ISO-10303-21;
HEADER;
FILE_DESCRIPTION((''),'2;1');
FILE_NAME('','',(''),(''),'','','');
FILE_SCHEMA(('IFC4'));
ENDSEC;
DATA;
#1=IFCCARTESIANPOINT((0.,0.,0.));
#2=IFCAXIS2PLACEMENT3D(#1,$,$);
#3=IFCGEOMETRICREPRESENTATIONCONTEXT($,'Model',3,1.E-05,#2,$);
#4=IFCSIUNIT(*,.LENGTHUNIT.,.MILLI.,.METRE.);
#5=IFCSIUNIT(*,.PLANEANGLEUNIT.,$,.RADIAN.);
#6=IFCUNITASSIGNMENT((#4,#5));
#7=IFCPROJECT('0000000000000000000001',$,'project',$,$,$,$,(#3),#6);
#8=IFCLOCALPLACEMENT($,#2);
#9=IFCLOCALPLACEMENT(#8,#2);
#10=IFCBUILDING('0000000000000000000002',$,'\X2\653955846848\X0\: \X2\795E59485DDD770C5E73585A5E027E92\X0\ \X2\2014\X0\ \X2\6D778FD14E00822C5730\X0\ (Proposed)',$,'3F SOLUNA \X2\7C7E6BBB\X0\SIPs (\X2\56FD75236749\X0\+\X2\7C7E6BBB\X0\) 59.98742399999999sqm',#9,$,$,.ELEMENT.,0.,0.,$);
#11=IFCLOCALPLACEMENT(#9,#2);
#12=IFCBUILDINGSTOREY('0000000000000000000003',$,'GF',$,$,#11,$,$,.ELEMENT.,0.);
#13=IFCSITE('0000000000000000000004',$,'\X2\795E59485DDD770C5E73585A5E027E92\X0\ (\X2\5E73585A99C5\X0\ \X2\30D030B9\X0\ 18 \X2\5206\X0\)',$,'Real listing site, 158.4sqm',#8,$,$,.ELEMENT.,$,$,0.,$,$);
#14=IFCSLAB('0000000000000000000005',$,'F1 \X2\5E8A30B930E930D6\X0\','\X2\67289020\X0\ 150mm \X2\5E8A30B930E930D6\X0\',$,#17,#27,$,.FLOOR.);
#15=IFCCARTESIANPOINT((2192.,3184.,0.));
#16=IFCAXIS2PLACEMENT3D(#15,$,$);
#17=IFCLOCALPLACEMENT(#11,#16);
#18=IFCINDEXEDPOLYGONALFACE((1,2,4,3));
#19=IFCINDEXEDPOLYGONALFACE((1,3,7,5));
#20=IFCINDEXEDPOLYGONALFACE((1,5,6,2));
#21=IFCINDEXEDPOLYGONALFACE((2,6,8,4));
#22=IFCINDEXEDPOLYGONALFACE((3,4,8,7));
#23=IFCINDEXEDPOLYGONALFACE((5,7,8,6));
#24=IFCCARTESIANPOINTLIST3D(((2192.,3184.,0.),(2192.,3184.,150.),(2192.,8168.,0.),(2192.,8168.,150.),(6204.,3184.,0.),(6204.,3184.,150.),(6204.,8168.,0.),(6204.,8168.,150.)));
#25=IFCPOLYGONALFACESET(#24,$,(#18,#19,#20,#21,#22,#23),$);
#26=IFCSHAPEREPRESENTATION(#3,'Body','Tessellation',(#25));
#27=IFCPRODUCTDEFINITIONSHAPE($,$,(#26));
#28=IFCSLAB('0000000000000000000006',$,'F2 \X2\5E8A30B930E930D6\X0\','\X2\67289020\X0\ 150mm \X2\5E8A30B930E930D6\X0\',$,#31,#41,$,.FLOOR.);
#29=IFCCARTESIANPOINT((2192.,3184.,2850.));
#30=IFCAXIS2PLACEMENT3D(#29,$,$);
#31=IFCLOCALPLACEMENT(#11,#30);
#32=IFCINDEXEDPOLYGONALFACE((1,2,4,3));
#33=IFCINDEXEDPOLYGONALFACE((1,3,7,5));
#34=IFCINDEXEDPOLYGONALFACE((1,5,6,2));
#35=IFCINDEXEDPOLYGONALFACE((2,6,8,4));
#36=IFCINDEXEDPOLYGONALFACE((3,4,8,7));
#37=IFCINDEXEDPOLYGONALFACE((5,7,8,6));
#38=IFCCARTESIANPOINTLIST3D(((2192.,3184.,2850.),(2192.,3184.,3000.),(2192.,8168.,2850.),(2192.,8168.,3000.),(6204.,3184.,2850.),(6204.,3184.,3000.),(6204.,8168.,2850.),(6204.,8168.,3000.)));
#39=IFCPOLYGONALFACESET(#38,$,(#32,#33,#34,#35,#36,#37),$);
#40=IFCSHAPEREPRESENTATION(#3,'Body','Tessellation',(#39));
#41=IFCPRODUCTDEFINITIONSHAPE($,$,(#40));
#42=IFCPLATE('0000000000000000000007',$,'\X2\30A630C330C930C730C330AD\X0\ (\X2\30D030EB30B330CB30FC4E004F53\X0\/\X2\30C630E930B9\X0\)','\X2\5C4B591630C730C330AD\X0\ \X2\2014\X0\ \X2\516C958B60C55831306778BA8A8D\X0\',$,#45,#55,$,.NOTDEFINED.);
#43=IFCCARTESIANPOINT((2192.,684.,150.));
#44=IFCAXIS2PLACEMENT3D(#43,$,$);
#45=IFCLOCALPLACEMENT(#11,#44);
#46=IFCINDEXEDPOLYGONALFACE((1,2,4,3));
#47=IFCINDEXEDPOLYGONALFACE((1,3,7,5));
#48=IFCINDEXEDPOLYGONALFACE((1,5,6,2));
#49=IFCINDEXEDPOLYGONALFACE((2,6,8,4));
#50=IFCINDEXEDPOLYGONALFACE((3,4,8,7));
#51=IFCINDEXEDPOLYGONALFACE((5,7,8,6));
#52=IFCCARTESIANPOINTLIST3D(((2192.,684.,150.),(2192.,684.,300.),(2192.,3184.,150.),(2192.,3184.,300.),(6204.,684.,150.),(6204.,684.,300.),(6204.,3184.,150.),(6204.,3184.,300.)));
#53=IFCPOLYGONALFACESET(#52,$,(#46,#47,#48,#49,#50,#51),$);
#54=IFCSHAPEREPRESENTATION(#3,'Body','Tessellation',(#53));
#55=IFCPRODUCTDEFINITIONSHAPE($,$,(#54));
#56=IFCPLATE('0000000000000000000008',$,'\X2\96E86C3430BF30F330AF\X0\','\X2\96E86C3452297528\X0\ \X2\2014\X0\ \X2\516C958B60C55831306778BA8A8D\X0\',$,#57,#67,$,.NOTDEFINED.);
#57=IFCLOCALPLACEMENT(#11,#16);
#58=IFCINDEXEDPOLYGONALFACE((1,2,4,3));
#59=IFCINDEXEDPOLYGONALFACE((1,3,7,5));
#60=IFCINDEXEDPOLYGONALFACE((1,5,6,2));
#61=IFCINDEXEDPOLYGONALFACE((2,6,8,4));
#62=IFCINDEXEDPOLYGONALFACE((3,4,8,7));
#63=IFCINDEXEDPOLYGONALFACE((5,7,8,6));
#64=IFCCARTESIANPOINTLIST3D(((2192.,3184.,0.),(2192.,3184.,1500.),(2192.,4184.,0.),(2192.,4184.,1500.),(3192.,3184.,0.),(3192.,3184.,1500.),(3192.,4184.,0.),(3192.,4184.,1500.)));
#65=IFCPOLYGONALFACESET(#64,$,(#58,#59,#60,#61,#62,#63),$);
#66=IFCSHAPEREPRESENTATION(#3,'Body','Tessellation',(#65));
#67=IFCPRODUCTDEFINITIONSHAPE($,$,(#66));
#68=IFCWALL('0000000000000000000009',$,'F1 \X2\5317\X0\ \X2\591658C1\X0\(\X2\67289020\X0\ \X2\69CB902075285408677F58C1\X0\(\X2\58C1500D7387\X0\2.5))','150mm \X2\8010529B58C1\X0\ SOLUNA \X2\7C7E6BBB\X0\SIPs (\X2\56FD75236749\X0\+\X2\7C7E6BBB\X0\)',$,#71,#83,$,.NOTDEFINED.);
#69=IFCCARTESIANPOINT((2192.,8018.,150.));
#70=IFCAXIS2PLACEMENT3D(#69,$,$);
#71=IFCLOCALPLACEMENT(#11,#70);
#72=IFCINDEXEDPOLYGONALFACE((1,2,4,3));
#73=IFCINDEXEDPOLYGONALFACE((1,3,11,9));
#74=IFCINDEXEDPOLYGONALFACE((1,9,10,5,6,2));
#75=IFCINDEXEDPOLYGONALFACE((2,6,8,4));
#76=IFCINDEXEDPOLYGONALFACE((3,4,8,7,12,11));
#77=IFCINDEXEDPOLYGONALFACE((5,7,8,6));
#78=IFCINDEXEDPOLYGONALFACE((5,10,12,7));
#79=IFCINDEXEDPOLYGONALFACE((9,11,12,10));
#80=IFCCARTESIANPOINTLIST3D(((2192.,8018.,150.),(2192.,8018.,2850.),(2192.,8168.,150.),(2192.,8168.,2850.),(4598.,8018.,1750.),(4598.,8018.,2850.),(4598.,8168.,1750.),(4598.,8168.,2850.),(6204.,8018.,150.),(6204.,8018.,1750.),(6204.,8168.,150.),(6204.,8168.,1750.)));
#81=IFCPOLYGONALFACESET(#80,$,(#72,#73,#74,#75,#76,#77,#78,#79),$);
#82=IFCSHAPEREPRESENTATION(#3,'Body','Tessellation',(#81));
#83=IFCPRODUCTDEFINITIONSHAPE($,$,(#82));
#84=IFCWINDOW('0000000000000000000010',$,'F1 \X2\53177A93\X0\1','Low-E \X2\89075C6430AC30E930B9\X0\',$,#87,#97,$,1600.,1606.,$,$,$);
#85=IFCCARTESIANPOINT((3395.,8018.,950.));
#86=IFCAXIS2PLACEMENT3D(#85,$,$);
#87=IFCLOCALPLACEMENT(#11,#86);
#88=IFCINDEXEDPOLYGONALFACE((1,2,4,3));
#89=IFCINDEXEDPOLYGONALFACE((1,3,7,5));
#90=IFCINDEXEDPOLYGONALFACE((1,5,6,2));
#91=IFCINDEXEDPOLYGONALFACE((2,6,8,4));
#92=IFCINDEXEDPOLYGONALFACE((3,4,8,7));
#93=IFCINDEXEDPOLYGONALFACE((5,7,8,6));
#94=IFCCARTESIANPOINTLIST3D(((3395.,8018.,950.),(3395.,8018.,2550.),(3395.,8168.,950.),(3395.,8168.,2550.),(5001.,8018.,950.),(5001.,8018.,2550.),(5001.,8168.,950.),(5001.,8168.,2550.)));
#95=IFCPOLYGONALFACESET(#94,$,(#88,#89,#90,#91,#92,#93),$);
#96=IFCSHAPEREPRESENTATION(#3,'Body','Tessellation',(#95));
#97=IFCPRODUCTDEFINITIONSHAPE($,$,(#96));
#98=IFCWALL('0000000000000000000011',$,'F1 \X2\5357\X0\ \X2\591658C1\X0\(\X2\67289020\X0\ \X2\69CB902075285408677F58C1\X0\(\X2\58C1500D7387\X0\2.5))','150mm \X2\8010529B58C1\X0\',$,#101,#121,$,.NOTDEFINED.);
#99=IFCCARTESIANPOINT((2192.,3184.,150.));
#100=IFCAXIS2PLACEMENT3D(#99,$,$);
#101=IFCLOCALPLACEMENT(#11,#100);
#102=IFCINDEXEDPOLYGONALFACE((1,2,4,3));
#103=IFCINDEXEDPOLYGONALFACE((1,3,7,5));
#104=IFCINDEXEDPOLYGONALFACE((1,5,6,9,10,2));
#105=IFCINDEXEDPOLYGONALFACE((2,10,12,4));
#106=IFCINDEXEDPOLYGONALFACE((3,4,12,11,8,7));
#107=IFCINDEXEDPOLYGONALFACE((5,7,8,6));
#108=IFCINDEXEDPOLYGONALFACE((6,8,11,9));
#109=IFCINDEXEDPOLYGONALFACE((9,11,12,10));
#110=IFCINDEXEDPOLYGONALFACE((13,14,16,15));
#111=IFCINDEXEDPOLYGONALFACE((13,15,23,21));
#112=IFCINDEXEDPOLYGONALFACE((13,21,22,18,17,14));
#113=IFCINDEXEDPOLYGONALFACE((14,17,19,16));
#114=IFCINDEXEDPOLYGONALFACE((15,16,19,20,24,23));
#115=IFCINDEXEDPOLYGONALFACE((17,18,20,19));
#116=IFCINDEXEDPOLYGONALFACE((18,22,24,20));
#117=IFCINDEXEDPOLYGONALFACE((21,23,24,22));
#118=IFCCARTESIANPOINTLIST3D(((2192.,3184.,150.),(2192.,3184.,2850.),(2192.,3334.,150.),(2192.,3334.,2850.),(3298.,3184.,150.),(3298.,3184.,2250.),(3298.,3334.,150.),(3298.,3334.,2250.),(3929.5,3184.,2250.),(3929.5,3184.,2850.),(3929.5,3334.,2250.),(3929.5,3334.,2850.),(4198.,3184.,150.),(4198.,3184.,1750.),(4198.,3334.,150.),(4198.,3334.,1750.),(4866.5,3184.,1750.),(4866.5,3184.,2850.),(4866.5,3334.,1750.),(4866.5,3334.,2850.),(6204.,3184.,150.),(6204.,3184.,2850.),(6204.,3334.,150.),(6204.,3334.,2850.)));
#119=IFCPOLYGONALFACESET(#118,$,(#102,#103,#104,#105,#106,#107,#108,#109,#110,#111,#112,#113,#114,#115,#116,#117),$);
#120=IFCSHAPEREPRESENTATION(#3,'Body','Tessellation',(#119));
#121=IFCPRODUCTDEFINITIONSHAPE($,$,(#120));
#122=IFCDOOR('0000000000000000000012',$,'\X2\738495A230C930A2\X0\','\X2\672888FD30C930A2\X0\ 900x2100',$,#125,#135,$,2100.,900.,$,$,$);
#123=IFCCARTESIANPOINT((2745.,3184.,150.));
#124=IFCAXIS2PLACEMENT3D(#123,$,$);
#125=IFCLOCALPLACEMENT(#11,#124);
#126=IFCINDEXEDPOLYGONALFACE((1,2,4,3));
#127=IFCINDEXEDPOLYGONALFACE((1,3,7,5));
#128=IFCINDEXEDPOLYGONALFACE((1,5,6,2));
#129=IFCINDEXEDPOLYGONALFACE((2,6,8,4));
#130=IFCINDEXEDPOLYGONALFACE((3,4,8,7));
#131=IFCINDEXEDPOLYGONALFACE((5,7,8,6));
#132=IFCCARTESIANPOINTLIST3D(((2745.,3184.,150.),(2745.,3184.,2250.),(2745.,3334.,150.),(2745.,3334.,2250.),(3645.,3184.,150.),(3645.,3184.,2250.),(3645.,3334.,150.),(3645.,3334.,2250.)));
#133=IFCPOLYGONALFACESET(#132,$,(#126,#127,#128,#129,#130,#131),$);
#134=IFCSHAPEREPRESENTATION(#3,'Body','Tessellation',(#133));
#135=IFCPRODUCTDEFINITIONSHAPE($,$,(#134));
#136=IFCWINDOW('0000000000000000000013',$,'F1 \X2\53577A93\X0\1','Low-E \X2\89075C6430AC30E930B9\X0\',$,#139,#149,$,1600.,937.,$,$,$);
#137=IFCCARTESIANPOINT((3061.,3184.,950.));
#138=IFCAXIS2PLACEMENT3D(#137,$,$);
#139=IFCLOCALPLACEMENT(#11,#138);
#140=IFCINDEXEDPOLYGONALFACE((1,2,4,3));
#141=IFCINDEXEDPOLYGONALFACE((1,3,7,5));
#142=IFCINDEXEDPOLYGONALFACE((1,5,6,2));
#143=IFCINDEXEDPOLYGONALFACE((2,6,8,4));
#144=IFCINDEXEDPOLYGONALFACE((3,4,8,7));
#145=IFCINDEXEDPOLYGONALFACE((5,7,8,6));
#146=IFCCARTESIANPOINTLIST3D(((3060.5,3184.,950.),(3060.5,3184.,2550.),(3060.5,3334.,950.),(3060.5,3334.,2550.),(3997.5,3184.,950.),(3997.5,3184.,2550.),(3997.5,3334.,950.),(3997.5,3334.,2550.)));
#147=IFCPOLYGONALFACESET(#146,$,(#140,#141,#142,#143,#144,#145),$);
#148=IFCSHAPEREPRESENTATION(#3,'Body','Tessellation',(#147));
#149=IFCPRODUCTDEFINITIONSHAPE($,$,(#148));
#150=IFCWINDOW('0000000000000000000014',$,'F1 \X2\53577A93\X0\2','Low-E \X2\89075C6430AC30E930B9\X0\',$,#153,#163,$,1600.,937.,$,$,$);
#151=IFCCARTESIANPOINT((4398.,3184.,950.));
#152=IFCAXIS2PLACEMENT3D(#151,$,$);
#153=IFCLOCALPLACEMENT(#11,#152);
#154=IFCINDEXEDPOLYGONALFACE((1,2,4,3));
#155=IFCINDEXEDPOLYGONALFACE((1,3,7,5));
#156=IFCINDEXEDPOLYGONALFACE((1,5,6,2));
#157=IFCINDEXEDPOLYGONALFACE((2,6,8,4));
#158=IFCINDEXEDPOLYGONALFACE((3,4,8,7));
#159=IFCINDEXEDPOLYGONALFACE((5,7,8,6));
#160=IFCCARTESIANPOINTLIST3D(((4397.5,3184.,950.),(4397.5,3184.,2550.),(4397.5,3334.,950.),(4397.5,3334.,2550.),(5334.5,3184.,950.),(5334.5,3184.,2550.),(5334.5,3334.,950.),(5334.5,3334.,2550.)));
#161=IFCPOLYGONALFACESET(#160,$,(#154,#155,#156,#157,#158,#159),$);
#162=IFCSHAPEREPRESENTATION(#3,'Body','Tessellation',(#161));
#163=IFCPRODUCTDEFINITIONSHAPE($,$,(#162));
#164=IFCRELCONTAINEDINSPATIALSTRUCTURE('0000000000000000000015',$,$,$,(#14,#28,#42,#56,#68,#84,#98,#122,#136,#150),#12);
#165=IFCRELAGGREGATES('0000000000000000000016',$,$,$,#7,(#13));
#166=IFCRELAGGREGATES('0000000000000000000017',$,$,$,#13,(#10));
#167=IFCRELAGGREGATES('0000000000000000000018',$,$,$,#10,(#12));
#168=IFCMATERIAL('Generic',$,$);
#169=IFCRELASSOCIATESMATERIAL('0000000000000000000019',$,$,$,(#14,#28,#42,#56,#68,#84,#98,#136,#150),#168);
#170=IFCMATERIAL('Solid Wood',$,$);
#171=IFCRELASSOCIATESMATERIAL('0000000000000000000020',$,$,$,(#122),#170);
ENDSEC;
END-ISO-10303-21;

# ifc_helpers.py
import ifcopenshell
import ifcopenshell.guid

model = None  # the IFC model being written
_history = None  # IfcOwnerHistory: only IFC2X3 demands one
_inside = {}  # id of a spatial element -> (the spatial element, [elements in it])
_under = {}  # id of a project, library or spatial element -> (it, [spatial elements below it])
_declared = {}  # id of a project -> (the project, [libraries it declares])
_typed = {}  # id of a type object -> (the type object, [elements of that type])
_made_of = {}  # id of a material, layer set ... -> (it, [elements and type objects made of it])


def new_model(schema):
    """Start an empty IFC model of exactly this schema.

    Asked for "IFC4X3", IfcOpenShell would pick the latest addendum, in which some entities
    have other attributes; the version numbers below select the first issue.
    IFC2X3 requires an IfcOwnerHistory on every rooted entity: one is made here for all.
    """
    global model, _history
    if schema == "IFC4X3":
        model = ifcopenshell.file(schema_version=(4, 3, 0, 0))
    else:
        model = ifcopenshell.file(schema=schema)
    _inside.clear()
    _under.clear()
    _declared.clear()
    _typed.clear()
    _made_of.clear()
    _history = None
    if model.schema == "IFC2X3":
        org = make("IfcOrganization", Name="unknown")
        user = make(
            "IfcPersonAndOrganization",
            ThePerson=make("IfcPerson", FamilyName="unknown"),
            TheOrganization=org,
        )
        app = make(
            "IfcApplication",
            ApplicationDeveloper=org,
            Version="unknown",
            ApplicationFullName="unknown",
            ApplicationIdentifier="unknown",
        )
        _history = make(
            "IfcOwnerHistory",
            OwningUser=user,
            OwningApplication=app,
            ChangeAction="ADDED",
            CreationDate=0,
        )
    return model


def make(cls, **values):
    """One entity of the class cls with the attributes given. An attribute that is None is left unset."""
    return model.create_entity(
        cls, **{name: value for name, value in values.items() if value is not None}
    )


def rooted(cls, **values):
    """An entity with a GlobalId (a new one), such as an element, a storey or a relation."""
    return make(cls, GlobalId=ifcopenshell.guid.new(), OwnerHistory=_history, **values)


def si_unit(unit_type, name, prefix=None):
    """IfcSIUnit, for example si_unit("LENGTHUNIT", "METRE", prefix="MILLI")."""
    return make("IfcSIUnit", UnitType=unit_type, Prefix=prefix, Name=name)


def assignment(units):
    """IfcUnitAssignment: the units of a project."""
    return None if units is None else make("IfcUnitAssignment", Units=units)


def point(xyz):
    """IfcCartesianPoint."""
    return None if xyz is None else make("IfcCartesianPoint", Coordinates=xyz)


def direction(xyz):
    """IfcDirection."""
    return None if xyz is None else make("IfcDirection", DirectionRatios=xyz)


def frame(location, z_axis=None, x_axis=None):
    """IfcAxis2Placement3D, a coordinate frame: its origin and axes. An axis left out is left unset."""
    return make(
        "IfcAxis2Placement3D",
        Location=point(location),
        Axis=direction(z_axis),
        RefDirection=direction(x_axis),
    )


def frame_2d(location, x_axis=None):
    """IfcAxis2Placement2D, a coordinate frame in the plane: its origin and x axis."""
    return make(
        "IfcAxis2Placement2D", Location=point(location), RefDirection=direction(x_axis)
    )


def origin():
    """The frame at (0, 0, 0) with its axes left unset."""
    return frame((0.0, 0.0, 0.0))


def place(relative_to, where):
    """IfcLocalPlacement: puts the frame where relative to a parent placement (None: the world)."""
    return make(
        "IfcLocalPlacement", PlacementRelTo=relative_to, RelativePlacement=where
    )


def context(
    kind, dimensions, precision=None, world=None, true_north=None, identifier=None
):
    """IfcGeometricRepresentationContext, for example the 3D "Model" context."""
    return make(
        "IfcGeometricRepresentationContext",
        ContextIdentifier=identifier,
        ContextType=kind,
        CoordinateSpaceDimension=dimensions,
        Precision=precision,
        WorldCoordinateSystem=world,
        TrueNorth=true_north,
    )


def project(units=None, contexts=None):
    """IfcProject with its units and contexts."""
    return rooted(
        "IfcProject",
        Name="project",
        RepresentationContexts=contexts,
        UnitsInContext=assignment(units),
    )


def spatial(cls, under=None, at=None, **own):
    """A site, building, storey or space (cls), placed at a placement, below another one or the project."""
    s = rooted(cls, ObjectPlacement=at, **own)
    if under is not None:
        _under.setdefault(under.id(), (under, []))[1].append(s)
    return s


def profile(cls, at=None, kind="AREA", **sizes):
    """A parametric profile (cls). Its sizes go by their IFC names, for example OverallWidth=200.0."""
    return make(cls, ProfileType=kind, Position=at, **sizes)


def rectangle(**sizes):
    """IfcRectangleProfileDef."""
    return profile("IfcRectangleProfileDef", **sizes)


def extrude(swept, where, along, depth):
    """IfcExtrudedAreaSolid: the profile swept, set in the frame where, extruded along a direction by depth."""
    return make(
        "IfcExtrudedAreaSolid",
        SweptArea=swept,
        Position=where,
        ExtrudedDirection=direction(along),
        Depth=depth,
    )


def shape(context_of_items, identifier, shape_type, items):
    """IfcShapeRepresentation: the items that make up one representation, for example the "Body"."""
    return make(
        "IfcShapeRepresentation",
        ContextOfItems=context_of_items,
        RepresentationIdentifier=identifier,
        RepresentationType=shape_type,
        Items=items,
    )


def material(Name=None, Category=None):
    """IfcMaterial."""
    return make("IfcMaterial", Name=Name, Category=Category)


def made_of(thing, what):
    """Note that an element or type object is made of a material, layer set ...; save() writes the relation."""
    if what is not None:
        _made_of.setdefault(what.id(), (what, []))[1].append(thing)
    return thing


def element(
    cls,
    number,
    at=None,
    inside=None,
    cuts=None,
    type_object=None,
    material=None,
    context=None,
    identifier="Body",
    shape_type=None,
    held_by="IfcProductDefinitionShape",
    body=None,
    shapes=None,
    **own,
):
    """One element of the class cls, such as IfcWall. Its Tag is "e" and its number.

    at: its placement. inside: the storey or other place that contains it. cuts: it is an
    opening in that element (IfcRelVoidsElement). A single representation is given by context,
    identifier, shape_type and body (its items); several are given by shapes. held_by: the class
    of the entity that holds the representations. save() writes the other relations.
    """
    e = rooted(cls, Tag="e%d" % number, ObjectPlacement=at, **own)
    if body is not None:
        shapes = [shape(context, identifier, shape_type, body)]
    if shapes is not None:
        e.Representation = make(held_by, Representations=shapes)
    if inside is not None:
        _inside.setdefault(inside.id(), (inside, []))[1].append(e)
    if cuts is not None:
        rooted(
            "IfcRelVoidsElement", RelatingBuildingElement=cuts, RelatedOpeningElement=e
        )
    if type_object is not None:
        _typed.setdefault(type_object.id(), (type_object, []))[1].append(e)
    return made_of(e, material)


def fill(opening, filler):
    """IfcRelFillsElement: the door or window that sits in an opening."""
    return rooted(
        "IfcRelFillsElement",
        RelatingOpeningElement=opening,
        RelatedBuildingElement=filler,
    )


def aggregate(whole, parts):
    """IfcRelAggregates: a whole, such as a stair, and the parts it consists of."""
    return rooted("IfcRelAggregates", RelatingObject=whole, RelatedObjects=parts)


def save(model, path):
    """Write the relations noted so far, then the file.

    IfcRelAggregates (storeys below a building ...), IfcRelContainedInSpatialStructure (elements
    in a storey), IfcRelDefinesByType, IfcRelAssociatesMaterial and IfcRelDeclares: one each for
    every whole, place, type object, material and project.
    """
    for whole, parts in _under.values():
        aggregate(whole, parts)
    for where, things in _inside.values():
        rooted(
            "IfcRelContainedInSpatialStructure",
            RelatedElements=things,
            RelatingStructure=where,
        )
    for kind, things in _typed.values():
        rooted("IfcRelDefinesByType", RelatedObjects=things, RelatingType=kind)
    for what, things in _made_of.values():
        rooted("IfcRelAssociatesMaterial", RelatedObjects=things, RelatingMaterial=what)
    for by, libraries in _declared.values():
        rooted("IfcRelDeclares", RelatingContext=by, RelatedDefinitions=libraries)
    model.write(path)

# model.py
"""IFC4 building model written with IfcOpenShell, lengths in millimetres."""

from ifc_helpers import new_model, si_unit, frame, frame_2d, origin, place, context, project, spatial, rectangle, extrude, material, element, fill, save


model = new_model("IFC4")

# Units and contexts
model_context = context("Model", 3, precision=1e-05, world=origin())
ifc_project = project(units=[si_unit("LENGTHUNIT", "METRE", prefix="MILLI"), si_unit("PLANEANGLEUNIT", "RADIAN")], contexts=[model_context])

# Site, building, storey
site_placement = place(None, origin())
site = spatial("IfcSite", under=ifc_project, at=site_placement, Name="神奈川県平塚市纒 (平塚駅 バス 18 分)", ObjectType="Real listing site, 158.4sqm", CompositionType="ELEMENT", RefElevation=0.0)
building_placement = place(site_placement, origin())
building = spatial("IfcBuilding", under=site, at=building_placement, Name="改善案: 神奈川県平塚市纒 — 海近一般地 (Proposed)", ObjectType="3F SOLUNA 籾殻SIPs (国産杉+籾殻) 59.98742399999999sqm", CompositionType="ELEMENT", ElevationOfRefHeight=0.0, ElevationOfTerrain=0.0)
storey_placement = place(building_placement, origin())
storey = spatial("IfcBuildingStorey", under=building, at=storey_placement, Name="GF", CompositionType="ELEMENT", Elevation=0.0)

# Slabs
ifc_material_1 = material(Name="Generic")
slab_1_placement = place(storey_placement, frame((2192.0, 3184.0, 0.0)))
element("IfcSlab", 1, at=slab_1_placement, inside=storey, material=ifc_material_1, Name="F1 床スラブ", Description="木造 150mm 床スラブ", PredefinedType="FLOOR", context=model_context, shape_type="SweptSolid", body=[
    extrude(rectangle(XDim=4012.0, YDim=4984.0, at=frame_2d((2006.0, 2492.0))), frame((2192.0, 3184.0, 0.0)), (0.0, 0.0, 1.0), 150.0),
])
slab_2_placement = place(storey_placement, frame((2192.0, 3184.0, 2850.0)))
element("IfcSlab", 2, at=slab_2_placement, inside=storey, material=ifc_material_1, Name="F2 床スラブ", Description="木造 150mm 床スラブ", PredefinedType="FLOOR", context=model_context, shape_type="SweptSolid", body=[
    extrude(rectangle(XDim=4012.0, YDim=4984.0, at=frame_2d((2006.0, 2492.0))), frame((2192.0, 3184.0, 2850.0)), (0.0, 0.0, 1.0), 150.0),
])

# Plates
plate_1_placement = place(storey_placement, frame((2192.0, 684.0, 150.0)))
element("IfcPlate", 3, at=plate_1_placement, inside=storey, material=ifc_material_1, Name="ウッドデッキ (バルコニー一体/テラス)", Description="屋外デッキ — 公開情報で確認", PredefinedType="NOTDEFINED", context=model_context, shape_type="SweptSolid", body=[
    extrude(rectangle(XDim=4012.0, YDim=2500.0, at=frame_2d((2006.0, 1250.0))), frame((2192.0, 684.0, 150.0)), (0.0, 0.0, 1.0), 150.0),
])
plate_2_placement = place(storey_placement, frame((2192.0, 3184.0, 0.0)))
element("IfcPlate", 4, at=plate_2_placement, inside=storey, material=ifc_material_1, Name="雨水タンク", Description="雨水利用 — 公開情報で確認", PredefinedType="NOTDEFINED", context=model_context, shape_type="SweptSolid", body=[
    extrude(rectangle(XDim=1000.0, YDim=1000.0, at=frame_2d((500.0, 500.0))), frame((2192.0, 3184.0, 0.0)), (0.0, 0.0, 1.0), 1500.0),
])

# Wall, opening, window
wall_1_placement = place(storey_placement, frame((2192.0, 8018.0, 150.0)))
wall_1 = element("IfcWall", 5, at=wall_1_placement, inside=storey, material=ifc_material_1, Name="F1 北 外壁(木造 構造用合板壁(壁倍率2.5))", Description="150mm 耐力壁 SOLUNA 籾殻SIPs (国産杉+籾殻)", PredefinedType="NOTDEFINED", context=model_context, shape_type="SweptSolid", body=[
    extrude(rectangle(XDim=4012.0, YDim=150.0, at=frame_2d((2006.0, 75.0))), frame((2192.0, 8018.0, 150.0)), (0.0, 0.0, 1.0), 2700.0),
])
opening_1_placement = place(storey_placement, frame((3395.0, 8018.0, 950.0)))
opening_1 = element("IfcOpeningElement", 6, at=opening_1_placement, cuts=wall_1, PredefinedType="NOTDEFINED", context=model_context, shape_type="SweptSolid", body=[
    extrude(rectangle(XDim=1606.0, YDim=150.0, at=frame_2d((803.0, 75.0))), frame((3395.0, 8018.0, 950.0)), (0.0, 0.0, 1.0), 1600.0),
])
window_1_placement = place(storey_placement, frame((3395.0, 8018.0, 950.0)))
window_1 = element("IfcWindow", 7, at=window_1_placement, inside=storey, material=ifc_material_1, Name="F1 北窓1", Description="Low-E 複層ガラス", OverallHeight=1600.0, OverallWidth=1606.0, context=model_context, shape_type="SweptSolid", body=[
    extrude(rectangle(XDim=1606.0, YDim=150.0, at=frame_2d((803.0, 75.0))), frame((3395.0, 8018.0, 950.0)), (0.0, 0.0, 1.0), 1600.0),
])
fill(opening_1, window_1)

# Wall, openings, door, windows
wall_2_placement = place(storey_placement, frame((2192.0, 3184.0, 150.0)))
wall_2 = element("IfcWall", 8, at=wall_2_placement, inside=storey, material=ifc_material_1, Name="F1 南 外壁(木造 構造用合板壁(壁倍率2.5))", Description="150mm 耐力壁", PredefinedType="NOTDEFINED", context=model_context, shape_type="SweptSolid", body=[
    extrude(rectangle(XDim=4012.0, YDim=150.0, at=frame_2d((2006.0, 75.0))), frame((2192.0, 3184.0, 150.0)), (0.0, 0.0, 1.0), 2700.0),
])
opening_2_placement = place(storey_placement, frame((2745.0, 3184.0, 150.0)))
opening_2 = element("IfcOpeningElement", 9, at=opening_2_placement, cuts=wall_2, PredefinedType="NOTDEFINED", context=model_context, shape_type="SweptSolid", body=[
    extrude(rectangle(XDim=900.0, YDim=150.0, at=frame_2d((450.0, 75.0))), frame((2745.0, 3184.0, 150.0)), (0.0, 0.0, 1.0), 2100.0),
])
opening_3_placement = place(storey_placement, frame((3061.0, 3184.0, 950.0)))
opening_3 = element("IfcOpeningElement", 10, at=opening_3_placement, cuts=wall_2, PredefinedType="NOTDEFINED", context=model_context, shape_type="SweptSolid", body=[
    extrude(rectangle(XDim=937.0, YDim=150.0, at=frame_2d((468.0, 75.0))), frame((3061.0, 3184.0, 950.0)), (0.0, 0.0, 1.0), 1600.0),
])
opening_4_placement = place(storey_placement, frame((4398.0, 3184.0, 950.0)))
opening_4 = element("IfcOpeningElement", 11, at=opening_4_placement, cuts=wall_2, PredefinedType="NOTDEFINED", context=model_context, shape_type="SweptSolid", body=[
    extrude(rectangle(XDim=937.0, YDim=150.0, at=frame_2d((468.0, 75.0))), frame((4398.0, 3184.0, 950.0)), (0.0, 0.0, 1.0), 1600.0),
])
ifc_material_2 = material(Name="Solid Wood")
door_placement = place(storey_placement, frame((2745.0, 3184.0, 150.0)))
door = element("IfcDoor", 12, at=door_placement, inside=storey, material=ifc_material_2, Name="玄関ドア", Description="木製ドア 900x2100", OverallHeight=2100.0, OverallWidth=900.0, context=model_context, shape_type="SweptSolid", body=[
    extrude(rectangle(XDim=900.0, YDim=150.0, at=frame_2d((450.0, 75.0))), frame((2745.0, 3184.0, 150.0)), (0.0, 0.0, 1.0), 2100.0),
])
fill(opening_2, door)
window_2_placement = place(storey_placement, frame((3061.0, 3184.0, 950.0)))
window_2 = element("IfcWindow", 13, at=window_2_placement, inside=storey, material=ifc_material_1, Name="F1 南窓1", Description="Low-E 複層ガラス", OverallHeight=1600.0, OverallWidth=937.0, context=model_context, shape_type="SweptSolid", body=[
    extrude(rectangle(XDim=937.0, YDim=150.0, at=frame_2d((468.0, 75.0))), frame((3061.0, 3184.0, 950.0)), (0.0, 0.0, 1.0), 1600.0),
])
fill(opening_3, window_2)
window_3_placement = place(storey_placement, frame((4398.0, 3184.0, 950.0)))
window_3 = element("IfcWindow", 14, at=window_3_placement, inside=storey, material=ifc_material_1, Name="F1 南窓2", Description="Low-E 複層ガラス", OverallHeight=1600.0, OverallWidth=937.0, context=model_context, shape_type="SweptSolid", body=[
    extrude(rectangle(XDim=937.0, YDim=150.0, at=frame_2d((468.0, 75.0))), frame((4398.0, 3184.0, 950.0)), (0.0, 0.0, 1.0), 1600.0),
])
fill(opening_4, window_3)

save(model, "model.ifc")
